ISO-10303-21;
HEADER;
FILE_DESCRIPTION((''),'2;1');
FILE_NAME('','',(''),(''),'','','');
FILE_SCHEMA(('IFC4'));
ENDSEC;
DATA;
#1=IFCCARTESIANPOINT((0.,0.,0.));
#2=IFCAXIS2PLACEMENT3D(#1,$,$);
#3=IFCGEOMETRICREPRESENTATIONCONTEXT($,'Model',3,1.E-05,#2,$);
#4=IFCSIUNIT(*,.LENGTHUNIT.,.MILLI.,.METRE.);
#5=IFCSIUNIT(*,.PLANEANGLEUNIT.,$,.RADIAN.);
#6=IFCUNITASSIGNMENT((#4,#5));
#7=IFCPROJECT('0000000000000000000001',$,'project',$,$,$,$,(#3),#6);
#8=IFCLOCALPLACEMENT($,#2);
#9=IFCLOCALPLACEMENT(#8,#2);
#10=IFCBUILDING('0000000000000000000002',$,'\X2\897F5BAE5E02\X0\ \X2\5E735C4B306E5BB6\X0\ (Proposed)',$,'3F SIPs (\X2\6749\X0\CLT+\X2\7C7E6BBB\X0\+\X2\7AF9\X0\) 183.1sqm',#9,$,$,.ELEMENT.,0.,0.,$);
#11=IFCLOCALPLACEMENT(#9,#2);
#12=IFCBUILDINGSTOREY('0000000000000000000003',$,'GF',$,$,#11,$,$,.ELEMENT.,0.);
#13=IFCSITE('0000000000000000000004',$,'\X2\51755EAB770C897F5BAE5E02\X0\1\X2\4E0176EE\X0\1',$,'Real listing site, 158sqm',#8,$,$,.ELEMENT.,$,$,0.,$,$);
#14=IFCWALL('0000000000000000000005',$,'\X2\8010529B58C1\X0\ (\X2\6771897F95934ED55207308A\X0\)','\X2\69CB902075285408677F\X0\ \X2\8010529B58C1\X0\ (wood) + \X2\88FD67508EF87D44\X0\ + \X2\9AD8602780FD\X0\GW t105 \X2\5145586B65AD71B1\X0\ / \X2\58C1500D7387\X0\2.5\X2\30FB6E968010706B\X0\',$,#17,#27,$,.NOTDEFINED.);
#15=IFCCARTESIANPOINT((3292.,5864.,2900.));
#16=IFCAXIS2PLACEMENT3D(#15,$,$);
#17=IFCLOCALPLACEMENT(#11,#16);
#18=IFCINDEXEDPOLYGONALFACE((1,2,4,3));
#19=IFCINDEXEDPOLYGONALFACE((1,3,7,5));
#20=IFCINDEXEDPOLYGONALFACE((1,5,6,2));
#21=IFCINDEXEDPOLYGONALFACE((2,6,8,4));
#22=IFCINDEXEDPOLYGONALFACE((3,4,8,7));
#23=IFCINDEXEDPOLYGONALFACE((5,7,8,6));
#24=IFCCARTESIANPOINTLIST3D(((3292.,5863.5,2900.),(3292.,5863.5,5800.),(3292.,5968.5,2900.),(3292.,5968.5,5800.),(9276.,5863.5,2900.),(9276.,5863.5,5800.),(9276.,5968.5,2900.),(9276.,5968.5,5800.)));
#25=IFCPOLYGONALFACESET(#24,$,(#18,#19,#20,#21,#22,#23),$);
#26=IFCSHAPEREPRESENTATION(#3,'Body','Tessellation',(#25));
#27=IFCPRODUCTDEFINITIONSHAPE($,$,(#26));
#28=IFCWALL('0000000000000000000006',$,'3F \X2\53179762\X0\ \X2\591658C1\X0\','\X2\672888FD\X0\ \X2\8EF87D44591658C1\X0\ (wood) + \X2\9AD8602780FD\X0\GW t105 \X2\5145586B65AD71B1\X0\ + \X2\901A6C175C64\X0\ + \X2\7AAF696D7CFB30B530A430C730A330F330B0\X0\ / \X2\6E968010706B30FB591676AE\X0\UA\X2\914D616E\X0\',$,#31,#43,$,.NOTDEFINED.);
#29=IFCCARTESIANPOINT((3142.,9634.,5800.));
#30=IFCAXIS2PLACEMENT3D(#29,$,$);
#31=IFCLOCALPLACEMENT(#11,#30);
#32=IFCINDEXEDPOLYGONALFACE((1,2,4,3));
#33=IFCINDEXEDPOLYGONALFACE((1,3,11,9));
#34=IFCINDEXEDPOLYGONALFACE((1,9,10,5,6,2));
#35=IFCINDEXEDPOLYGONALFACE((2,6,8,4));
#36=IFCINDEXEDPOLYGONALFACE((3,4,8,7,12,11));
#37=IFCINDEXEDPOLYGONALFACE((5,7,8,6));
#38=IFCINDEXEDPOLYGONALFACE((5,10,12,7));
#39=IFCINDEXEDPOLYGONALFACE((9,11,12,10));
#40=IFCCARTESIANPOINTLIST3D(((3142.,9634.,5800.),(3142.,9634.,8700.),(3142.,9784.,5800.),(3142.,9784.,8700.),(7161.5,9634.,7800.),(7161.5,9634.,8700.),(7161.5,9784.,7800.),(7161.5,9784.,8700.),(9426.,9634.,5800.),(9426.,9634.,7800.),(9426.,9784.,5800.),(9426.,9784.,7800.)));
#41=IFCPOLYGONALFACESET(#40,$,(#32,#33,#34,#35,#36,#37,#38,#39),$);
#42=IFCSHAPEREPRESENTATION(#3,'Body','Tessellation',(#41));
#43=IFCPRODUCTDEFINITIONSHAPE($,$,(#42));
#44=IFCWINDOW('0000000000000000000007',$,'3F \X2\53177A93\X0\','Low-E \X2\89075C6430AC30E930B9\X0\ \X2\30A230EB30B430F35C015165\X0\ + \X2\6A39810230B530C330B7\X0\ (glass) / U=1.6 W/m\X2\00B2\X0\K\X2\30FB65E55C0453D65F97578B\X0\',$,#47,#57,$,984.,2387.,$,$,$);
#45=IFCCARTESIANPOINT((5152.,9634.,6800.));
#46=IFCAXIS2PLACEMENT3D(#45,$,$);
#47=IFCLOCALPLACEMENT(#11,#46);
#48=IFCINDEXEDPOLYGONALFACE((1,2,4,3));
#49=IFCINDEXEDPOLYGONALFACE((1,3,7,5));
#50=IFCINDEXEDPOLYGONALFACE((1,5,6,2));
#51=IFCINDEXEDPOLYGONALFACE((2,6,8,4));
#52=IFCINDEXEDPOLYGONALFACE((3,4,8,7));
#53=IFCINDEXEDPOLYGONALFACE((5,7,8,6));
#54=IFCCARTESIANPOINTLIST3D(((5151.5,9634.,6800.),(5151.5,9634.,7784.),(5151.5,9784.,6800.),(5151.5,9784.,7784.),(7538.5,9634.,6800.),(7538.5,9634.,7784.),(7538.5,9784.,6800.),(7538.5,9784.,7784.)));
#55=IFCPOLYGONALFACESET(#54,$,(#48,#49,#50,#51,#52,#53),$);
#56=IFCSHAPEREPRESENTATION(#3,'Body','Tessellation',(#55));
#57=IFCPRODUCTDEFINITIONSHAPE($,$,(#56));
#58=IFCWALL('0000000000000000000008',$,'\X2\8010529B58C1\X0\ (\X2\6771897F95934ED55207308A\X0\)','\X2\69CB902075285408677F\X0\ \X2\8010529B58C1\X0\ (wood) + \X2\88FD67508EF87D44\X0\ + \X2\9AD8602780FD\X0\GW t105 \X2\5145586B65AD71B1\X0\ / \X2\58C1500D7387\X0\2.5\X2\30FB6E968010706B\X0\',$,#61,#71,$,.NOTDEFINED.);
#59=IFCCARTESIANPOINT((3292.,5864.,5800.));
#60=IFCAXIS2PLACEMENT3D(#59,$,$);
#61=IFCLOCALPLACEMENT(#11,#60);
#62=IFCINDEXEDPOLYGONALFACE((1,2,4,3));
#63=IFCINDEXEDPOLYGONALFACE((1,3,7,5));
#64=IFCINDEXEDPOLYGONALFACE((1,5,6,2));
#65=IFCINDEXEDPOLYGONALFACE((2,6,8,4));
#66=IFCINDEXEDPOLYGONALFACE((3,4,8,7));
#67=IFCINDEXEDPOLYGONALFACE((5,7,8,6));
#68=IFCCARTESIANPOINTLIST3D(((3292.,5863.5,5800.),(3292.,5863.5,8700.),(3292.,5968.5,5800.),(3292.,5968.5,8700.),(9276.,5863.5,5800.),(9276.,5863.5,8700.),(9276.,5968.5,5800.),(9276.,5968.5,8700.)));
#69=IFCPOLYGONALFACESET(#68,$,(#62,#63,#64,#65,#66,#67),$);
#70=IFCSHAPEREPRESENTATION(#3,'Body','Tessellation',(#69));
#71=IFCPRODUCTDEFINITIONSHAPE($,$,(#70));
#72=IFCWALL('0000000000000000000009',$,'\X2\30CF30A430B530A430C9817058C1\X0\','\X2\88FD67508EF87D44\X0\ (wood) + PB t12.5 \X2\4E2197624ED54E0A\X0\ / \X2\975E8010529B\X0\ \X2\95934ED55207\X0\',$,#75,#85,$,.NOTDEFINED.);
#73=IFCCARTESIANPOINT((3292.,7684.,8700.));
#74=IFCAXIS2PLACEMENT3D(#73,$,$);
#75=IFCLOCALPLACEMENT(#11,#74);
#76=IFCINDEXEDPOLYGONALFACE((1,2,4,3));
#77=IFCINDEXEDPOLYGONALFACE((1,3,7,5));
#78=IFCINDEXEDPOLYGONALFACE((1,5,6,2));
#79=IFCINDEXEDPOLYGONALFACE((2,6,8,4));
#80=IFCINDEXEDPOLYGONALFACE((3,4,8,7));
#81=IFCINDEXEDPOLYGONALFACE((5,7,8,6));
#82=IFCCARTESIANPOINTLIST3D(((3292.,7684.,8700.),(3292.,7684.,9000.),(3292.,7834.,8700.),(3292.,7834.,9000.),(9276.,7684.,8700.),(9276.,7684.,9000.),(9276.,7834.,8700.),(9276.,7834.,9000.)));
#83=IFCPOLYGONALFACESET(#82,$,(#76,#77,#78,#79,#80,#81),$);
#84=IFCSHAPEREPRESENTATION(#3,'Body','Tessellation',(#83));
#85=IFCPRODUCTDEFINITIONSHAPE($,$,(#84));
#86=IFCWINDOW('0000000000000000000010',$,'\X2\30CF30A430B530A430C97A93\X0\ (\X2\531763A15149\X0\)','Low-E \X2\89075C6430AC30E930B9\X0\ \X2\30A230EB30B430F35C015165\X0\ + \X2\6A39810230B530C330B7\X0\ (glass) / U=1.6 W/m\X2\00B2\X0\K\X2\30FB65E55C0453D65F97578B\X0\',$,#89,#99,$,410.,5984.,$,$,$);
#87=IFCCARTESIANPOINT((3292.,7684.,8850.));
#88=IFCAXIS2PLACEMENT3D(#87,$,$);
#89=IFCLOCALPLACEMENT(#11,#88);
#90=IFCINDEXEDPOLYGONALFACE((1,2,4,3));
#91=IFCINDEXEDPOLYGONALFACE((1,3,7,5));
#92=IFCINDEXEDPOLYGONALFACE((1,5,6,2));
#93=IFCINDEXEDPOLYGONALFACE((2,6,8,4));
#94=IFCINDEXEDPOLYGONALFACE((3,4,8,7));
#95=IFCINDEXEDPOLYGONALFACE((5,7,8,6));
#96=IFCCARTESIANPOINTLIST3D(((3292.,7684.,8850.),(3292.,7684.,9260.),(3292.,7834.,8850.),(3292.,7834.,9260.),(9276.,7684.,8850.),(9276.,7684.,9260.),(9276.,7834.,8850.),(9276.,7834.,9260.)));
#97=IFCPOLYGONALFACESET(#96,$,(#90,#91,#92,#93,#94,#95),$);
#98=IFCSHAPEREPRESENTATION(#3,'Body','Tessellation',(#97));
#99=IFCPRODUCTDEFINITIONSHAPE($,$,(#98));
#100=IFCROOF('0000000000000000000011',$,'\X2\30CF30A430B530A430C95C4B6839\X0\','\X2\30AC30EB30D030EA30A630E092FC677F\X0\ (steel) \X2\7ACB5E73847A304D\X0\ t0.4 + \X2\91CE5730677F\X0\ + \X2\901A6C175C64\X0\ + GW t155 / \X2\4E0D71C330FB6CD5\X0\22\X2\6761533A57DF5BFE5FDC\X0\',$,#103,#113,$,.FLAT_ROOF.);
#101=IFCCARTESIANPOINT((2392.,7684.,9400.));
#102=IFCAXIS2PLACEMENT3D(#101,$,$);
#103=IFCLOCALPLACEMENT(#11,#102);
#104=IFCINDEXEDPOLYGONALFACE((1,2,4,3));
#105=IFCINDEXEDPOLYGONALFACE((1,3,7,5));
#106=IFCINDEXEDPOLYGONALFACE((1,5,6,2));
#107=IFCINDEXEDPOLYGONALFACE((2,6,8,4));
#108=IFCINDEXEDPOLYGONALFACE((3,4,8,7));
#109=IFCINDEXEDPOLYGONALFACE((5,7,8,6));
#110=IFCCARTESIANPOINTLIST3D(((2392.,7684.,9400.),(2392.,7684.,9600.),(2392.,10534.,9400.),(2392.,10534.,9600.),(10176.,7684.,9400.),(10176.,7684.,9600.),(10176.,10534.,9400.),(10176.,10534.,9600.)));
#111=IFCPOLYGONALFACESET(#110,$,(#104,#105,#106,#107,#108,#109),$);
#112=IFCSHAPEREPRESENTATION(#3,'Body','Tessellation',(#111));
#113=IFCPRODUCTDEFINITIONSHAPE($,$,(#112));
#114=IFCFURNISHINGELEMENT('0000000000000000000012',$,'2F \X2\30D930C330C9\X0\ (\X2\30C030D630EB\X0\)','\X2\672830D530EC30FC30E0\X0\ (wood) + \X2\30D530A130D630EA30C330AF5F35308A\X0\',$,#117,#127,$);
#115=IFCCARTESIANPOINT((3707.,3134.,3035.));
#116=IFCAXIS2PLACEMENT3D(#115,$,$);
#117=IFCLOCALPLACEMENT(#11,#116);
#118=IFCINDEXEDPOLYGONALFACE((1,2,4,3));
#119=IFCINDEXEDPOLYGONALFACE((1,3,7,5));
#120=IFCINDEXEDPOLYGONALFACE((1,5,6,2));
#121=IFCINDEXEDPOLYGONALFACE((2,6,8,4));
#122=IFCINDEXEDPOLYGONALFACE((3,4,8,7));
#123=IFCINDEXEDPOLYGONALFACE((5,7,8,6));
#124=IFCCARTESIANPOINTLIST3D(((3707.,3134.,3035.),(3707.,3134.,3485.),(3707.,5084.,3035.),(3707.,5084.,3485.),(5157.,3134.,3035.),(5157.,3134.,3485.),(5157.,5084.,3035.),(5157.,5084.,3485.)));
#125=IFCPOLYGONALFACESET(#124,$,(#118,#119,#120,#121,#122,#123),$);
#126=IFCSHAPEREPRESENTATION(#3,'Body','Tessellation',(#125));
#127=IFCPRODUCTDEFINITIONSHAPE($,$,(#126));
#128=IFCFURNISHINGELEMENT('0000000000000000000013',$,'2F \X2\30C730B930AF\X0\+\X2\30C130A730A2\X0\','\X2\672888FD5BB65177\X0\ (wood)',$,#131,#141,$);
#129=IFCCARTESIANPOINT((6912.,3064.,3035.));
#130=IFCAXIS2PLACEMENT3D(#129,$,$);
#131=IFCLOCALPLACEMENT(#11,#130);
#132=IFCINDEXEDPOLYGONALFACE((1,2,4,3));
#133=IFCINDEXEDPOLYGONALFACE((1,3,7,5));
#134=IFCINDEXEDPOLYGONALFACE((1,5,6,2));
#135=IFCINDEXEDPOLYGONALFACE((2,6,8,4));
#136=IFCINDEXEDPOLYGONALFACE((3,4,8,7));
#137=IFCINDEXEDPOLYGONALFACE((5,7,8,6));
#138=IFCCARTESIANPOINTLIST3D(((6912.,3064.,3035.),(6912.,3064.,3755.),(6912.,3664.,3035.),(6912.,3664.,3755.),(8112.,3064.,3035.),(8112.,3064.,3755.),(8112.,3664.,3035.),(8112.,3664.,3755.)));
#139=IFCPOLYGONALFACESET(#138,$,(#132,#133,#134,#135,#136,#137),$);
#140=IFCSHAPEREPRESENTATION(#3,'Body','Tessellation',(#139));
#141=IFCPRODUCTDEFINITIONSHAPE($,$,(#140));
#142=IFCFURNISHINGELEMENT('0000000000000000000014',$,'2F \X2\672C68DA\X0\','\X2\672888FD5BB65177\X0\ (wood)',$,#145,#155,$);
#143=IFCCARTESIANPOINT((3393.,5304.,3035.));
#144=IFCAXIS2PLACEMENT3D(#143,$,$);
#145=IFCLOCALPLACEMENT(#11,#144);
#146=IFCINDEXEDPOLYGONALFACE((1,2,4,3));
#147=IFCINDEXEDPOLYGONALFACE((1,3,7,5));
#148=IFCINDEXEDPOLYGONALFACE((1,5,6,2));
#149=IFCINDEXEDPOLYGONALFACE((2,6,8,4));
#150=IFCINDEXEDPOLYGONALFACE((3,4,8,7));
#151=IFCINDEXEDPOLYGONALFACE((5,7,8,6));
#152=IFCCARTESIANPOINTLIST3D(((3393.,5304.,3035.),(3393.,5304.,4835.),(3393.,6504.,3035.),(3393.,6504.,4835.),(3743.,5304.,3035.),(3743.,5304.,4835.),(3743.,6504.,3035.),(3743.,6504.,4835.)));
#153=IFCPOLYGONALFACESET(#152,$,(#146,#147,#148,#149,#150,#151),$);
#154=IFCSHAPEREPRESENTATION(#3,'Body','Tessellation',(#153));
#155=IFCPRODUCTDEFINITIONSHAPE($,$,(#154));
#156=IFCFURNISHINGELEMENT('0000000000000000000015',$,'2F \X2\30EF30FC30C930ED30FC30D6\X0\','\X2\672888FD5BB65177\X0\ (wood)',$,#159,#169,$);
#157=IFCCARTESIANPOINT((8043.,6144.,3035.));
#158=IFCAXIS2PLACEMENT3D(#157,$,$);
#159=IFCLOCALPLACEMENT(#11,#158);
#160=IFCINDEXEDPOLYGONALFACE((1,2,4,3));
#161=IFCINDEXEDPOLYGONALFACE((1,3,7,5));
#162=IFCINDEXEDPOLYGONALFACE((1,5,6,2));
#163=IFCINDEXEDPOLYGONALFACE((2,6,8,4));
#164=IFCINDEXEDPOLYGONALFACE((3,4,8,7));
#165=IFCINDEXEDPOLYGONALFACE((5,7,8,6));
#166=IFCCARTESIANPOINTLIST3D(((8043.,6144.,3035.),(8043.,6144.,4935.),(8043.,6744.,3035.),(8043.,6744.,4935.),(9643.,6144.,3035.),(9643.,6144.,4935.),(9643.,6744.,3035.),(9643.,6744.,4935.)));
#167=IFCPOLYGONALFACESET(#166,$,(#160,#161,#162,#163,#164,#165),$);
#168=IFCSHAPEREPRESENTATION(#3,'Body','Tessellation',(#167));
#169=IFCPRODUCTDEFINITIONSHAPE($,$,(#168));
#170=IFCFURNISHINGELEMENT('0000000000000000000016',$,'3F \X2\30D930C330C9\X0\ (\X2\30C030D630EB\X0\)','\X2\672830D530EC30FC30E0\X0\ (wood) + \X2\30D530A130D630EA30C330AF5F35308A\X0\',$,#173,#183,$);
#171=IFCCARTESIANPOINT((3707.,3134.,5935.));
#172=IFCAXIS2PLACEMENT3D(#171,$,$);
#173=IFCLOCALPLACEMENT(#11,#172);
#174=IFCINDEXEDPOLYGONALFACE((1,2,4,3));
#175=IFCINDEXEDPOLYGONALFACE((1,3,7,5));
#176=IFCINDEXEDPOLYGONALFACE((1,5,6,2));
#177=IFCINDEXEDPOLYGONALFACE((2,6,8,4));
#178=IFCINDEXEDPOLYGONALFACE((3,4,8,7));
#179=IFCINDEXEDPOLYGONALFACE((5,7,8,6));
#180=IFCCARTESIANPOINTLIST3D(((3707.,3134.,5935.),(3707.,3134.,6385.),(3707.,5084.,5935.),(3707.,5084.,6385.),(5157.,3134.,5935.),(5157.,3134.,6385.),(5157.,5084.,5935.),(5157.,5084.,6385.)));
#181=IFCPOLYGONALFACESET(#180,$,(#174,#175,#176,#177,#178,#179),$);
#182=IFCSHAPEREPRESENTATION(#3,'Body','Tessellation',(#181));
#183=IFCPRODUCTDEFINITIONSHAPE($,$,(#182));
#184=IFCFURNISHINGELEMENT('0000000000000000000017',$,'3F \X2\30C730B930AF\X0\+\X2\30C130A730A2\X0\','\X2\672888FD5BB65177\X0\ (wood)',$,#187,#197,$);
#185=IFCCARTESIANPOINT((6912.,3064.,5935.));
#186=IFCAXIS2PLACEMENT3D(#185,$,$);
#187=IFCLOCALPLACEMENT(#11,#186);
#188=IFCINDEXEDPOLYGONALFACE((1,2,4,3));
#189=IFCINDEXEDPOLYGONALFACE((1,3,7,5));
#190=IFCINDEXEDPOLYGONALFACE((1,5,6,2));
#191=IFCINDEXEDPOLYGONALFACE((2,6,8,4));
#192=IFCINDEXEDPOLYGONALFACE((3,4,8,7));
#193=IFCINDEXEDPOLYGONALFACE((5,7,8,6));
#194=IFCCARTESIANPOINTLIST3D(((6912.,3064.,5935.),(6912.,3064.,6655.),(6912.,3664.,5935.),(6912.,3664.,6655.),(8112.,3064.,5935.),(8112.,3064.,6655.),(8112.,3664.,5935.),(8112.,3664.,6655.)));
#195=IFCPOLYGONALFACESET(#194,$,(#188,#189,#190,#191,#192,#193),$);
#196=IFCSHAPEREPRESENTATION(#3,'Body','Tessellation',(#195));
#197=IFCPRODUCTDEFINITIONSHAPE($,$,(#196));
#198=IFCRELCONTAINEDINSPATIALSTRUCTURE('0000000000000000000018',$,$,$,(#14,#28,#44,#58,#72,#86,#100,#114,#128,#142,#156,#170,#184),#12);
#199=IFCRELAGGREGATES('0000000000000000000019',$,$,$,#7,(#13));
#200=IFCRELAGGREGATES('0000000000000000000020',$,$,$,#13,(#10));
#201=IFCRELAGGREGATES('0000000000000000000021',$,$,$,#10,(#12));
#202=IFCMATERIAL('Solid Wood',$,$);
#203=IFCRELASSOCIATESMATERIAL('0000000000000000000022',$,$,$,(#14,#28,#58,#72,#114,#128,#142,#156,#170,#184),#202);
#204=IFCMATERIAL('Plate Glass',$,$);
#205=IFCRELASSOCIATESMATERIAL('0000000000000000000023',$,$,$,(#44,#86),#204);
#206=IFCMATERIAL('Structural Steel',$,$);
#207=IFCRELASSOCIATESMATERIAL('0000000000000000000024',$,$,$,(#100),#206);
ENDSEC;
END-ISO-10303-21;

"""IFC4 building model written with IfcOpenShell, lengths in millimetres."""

from ifc_helpers import new_model, si_unit, frame, frame_2d, origin, place, context, project, spatial, rectangle, extrude, material, element, fill, save


model = new_model("IFC4")

# Units and contexts
model_context = context("Model", 3, precision=1e-05, world=origin())
ifc_project = project(units=[si_unit("LENGTHUNIT", "METRE", prefix="MILLI"), si_unit("PLANEANGLEUNIT", "RADIAN")], contexts=[model_context])

# Site, building, storey
site_placement = place(None, origin())
site = spatial("IfcSite", under=ifc_project, at=site_placement, Name="兵庫県西宮市1丁目1", ObjectType="Real listing site, 158sqm", CompositionType="ELEMENT", RefElevation=0.0)
building_placement = place(site_placement, origin())
building = spatial("IfcBuilding", under=site, at=building_placement, Name="西宮市 平屋の家 (Proposed)", ObjectType="3F SIPs (杉CLT+籾殻+竹) 183.1sqm", CompositionType="ELEMENT", ElevationOfRefHeight=0.0, ElevationOfTerrain=0.0)
storey_placement = place(building_placement, origin())
storey = spatial("IfcBuildingStorey", under=building, at=storey_placement, Name="GF", CompositionType="ELEMENT", Elevation=0.0)

# Wall
ifc_material_1 = material(Name="Solid Wood")
wall_1_placement = place(storey_placement, frame((3292.0, 5864.0, 2900.0)))
element("IfcWall", 1, at=wall_1_placement, inside=storey, material=ifc_material_1, Name="耐力壁 (東西間仕切り)", Description="構造用合板 耐力壁 (wood) + 製材軸組 + 高性能GW t105 充填断熱 / 壁倍率2.5・準耐火", PredefinedType="NOTDEFINED", context=model_context, shape_type="SweptSolid", body=[
    extrude(rectangle(XDim=5984.0, YDim=105.0, at=frame_2d((2992.0, 52.0))), frame((3292.0, 5864.0, 2900.0)), (0.0, 0.0, 1.0), 2900.0),
])

# Wall, opening, window
wall_2_placement = place(storey_placement, frame((3142.0, 9634.0, 5800.0)))
wall_2 = element("IfcWall", 2, at=wall_2_placement, inside=storey, material=ifc_material_1, Name="3F 北面 外壁", Description="木製 軸組外壁 (wood) + 高性能GW t105 充填断熱 + 通気層 + 窯業系サイディング / 準耐火・外皮UA配慮", PredefinedType="NOTDEFINED", context=model_context, shape_type="SweptSolid", body=[
    extrude(rectangle(XDim=6284.0, YDim=150.0, at=frame_2d((3142.0, 75.0))), frame((3142.0, 9634.0, 5800.0)), (0.0, 0.0, 1.0), 2900.0),
])
opening_1_placement = place(storey_placement, frame((5152.0, 9634.0, 6800.0)))
opening_1 = element("IfcOpeningElement", 3, at=opening_1_placement, cuts=wall_2, PredefinedType="NOTDEFINED", context=model_context, shape_type="SweptSolid", body=[
    extrude(rectangle(XDim=2387.0, YDim=150.0, at=frame_2d((1193.0, 75.0))), frame((5152.0, 9634.0, 6800.0)), (0.0, 0.0, 1.0), 984.0),
])
ifc_material_2 = material(Name="Plate Glass")
window_1_placement = place(storey_placement, frame((5152.0, 9634.0, 6800.0)))
window_1 = element("IfcWindow", 4, at=window_1_placement, inside=storey, material=ifc_material_2, Name="3F 北窓", Description="Low-E 複層ガラス アルゴン封入 + 樹脂サッシ (glass) / U=1.6 W/m²K・日射取得型", OverallHeight=984.0, OverallWidth=2387.0, context=model_context, shape_type="SweptSolid", body=[
    extrude(rectangle(XDim=2387.0, YDim=150.0, at=frame_2d((1193.0, 75.0))), frame((5152.0, 9634.0, 6800.0)), (0.0, 0.0, 1.0), 984.0),
])
fill(opening_1, window_1)

# Wall
wall_3_placement = place(storey_placement, frame((3292.0, 5864.0, 5800.0)))
element("IfcWall", 5, at=wall_3_placement, inside=storey, material=ifc_material_1, Name="耐力壁 (東西間仕切り)", Description="構造用合板 耐力壁 (wood) + 製材軸組 + 高性能GW t105 充填断熱 / 壁倍率2.5・準耐火", PredefinedType="NOTDEFINED", context=model_context, shape_type="SweptSolid", body=[
    extrude(rectangle(XDim=5984.0, YDim=105.0, at=frame_2d((2992.0, 52.0))), frame((3292.0, 5864.0, 5800.0)), (0.0, 0.0, 1.0), 2900.0),
])

# Wall, opening, window
wall_4_placement = place(storey_placement, frame((3292.0, 7684.0, 8700.0)))
wall_4 = element("IfcWall", 6, at=wall_4_placement, inside=storey, material=ifc_material_1, Name="ハイサイド腰壁", Description="製材軸組 (wood) + PB t12.5 両面仕上 / 非耐力 間仕切", PredefinedType="NOTDEFINED", context=model_context, shape_type="SweptSolid", body=[
    extrude(rectangle(XDim=5984.0, YDim=150.0, at=frame_2d((2992.0, 75.0))), frame((3292.0, 7684.0, 8700.0)), (0.0, 0.0, 1.0), 700.0),
])
opening_2_placement = place(storey_placement, frame((3292.0, 7684.0, 8850.0)))
opening_2 = element("IfcOpeningElement", 7, at=opening_2_placement, cuts=wall_4, PredefinedType="NOTDEFINED", context=model_context, shape_type="SweptSolid", body=[
    extrude(rectangle(XDim=5984.0, YDim=150.0, at=frame_2d((2992.0, 75.0))), frame((3292.0, 7684.0, 8850.0)), (0.0, 0.0, 1.0), 410.0),
])
window_2_placement = place(storey_placement, frame((3292.0, 7684.0, 8850.0)))
window_2 = element("IfcWindow", 8, at=window_2_placement, inside=storey, material=ifc_material_2, Name="ハイサイド窓 (北採光)", Description="Low-E 複層ガラス アルゴン封入 + 樹脂サッシ (glass) / U=1.6 W/m²K・日射取得型", OverallHeight=410.0, OverallWidth=5984.0, context=model_context, shape_type="SweptSolid", body=[
    extrude(rectangle(XDim=5984.0, YDim=150.0, at=frame_2d((2992.0, 75.0))), frame((3292.0, 7684.0, 8850.0)), (0.0, 0.0, 1.0), 410.0),
])
fill(opening_2, window_2)

# Roof
ifc_material_3 = material(Name="Structural Steel")
roof_placement = place(storey_placement, frame((2392.0, 7684.0, 9400.0)))
element("IfcRoof", 9, at=roof_placement, inside=storey, material=ifc_material_3, Name="ハイサイド屋根", Description="ガルバリウム鋼板 (steel) 立平葺き t0.4 + 野地板 + 通気層 + GW t155 / 不燃・法22条区域対応", PredefinedType="FLAT_ROOF", context=model_context, shape_type="SweptSolid", body=[
    extrude(rectangle(XDim=7784.0, YDim=2850.0, at=frame_2d((3892.0, 1425.0))), frame((2392.0, 7684.0, 9400.0)), (0.0, 0.0, 1.0), 200.0),
])

# Furnishing elements
furnishing_1_placement = place(storey_placement, frame((3707.0, 3134.0, 3035.0)))
element("IfcFurnishingElement", 10, at=furnishing_1_placement, inside=storey, material=ifc_material_1, Name="2F ベッド (ダブル)", Description="木フレーム (wood) + ファブリック張り", context=model_context, shape_type="SweptSolid", body=[
    extrude(rectangle(XDim=1450.0, YDim=1950.0, at=frame_2d((725.0, 975.0))), frame((3707.0, 3134.0, 3035.0)), (0.0, 0.0, 1.0), 450.0),
])
furnishing_2_placement = place(storey_placement, frame((6912.0, 3064.0, 3035.0)))
element("IfcFurnishingElement", 11, at=furnishing_2_placement, inside=storey, material=ifc_material_1, Name="2F デスク+チェア", Description="木製家具 (wood)", context=model_context, shape_type="SweptSolid", body=[
    extrude(rectangle(XDim=1200.0, YDim=600.0, at=frame_2d((600.0, 300.0))), frame((6912.0, 3064.0, 3035.0)), (0.0, 0.0, 1.0), 720.0),
])
furnishing_3_placement = place(storey_placement, frame((3393.0, 5304.0, 3035.0)))
element("IfcFurnishingElement", 12, at=furnishing_3_placement, inside=storey, material=ifc_material_1, Name="2F 本棚", Description="木製家具 (wood)", context=model_context, shape_type="SweptSolid", body=[
    extrude(rectangle(XDim=350.0, YDim=1200.0, at=frame_2d((175.0, 600.0))), frame((3393.0, 5304.0, 3035.0)), (0.0, 0.0, 1.0), 1800.0),
])
furnishing_4_placement = place(storey_placement, frame((8043.0, 6144.0, 3035.0)))
element("IfcFurnishingElement", 13, at=furnishing_4_placement, inside=storey, material=ifc_material_1, Name="2F ワードローブ", Description="木製家具 (wood)", context=model_context, shape_type="SweptSolid", body=[
    extrude(rectangle(XDim=1600.0, YDim=600.0, at=frame_2d((800.0, 300.0))), frame((8043.0, 6144.0, 3035.0)), (0.0, 0.0, 1.0), 1900.0),
])
furnishing_5_placement = place(storey_placement, frame((3707.0, 3134.0, 5935.0)))
element("IfcFurnishingElement", 14, at=furnishing_5_placement, inside=storey, material=ifc_material_1, Name="3F ベッド (ダブル)", Description="木フレーム (wood) + ファブリック張り", context=model_context, shape_type="SweptSolid", body=[
    extrude(rectangle(XDim=1450.0, YDim=1950.0, at=frame_2d((725.0, 975.0))), frame((3707.0, 3134.0, 5935.0)), (0.0, 0.0, 1.0), 450.0),
])
furnishing_6_placement = place(storey_placement, frame((6912.0, 3064.0, 5935.0)))
element("IfcFurnishingElement", 15, at=furnishing_6_placement, inside=storey, material=ifc_material_1, Name="3F デスク+チェア", Description="木製家具 (wood)", context=model_context, shape_type="SweptSolid", body=[
    extrude(rectangle(XDim=1200.0, YDim=600.0, at=frame_2d((600.0, 300.0))), frame((6912.0, 3064.0, 5935.0)), (0.0, 0.0, 1.0), 720.0),
])

save(model, "model.ifc")
